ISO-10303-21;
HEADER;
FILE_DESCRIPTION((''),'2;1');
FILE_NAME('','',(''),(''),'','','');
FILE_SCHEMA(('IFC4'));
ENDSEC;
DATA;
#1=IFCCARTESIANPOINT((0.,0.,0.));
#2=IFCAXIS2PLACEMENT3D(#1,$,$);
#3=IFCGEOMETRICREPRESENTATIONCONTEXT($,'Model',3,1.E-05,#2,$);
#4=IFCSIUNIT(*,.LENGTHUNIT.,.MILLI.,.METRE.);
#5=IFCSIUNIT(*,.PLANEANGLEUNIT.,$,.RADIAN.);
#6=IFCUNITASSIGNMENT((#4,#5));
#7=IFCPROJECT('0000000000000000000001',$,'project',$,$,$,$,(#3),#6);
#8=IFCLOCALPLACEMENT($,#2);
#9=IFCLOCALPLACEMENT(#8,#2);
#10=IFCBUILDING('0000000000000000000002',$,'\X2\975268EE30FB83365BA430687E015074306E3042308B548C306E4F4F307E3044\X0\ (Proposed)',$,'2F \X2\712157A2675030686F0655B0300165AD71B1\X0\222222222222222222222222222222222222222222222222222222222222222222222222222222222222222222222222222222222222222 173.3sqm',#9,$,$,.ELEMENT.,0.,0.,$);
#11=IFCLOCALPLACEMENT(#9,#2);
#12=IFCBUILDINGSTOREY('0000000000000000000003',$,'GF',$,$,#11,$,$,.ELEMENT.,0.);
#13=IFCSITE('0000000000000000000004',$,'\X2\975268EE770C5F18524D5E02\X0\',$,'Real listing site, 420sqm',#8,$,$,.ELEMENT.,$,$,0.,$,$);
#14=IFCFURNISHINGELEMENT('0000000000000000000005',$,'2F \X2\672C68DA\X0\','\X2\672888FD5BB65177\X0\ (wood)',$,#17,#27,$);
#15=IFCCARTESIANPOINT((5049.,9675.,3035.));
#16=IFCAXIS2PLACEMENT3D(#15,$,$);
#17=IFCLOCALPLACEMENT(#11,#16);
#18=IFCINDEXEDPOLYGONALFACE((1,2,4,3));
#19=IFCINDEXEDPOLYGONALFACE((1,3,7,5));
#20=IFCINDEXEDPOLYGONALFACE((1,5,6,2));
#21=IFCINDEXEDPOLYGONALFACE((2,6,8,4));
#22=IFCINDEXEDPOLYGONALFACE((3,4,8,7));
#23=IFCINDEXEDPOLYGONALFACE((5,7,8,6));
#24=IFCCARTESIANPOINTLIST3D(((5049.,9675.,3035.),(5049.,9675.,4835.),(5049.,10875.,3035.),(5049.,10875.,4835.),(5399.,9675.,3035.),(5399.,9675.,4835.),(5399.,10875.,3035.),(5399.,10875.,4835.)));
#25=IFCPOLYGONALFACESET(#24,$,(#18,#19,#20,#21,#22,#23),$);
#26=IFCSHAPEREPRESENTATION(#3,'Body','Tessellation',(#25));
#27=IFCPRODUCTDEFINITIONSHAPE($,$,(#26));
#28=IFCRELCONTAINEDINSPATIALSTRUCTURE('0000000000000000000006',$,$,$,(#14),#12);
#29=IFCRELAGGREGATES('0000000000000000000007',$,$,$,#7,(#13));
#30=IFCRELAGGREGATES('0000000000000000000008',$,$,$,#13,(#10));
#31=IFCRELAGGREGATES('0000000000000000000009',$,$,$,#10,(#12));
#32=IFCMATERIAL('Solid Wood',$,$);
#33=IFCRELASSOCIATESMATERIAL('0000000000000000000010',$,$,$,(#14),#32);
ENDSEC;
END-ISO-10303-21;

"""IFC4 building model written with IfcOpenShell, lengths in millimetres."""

from ifc_helpers import new_model, si_unit, frame, frame_2d, origin, place, context, project, spatial, rectangle, extrude, material, element, save


model = new_model("IFC4")

# Units and contexts
model_context = context("Model", 3, precision=1e-05, world=origin())
ifc_project = project(units=[si_unit("LENGTHUNIT", "METRE", prefix="MILLI"), si_unit("PLANEANGLEUNIT", "RADIAN")], contexts=[model_context])

# Site, building, storey
site_placement = place(None, origin())
site = spatial("IfcSite", under=ifc_project, at=site_placement, Name="青森県弘前市", ObjectType="Real listing site, 420sqm", CompositionType="ELEMENT", RefElevation=0.0)
building_placement = place(site_placement, origin())
building = spatial("IfcBuilding", under=site, at=building_placement, Name="青森・茶室と縁側のある和の住まい (Proposed)", ObjectType="2F 無垢材と漆喰、断熱222222222222222222222222222222222222222222222222222222222222222222222222222222222222222222222222222222222222222 173.3sqm", CompositionType="ELEMENT", ElevationOfRefHeight=0.0, ElevationOfTerrain=0.0)
storey_placement = place(building_placement, origin())
storey = spatial("IfcBuildingStorey", under=building, at=storey_placement, Name="GF", CompositionType="ELEMENT", Elevation=0.0)

# Shared definitions
ifc_material_1 = material(Name="Solid Wood")

# Furnishing element
furnishing_1_placement = place(storey_placement, frame((5049.0, 9675.0, 3035.0)))
element("IfcFurnishingElement", 1, at=furnishing_1_placement, inside=storey, material=ifc_material_1, Name="2F 本棚", Description="木製家具 (wood)", context=model_context, shape_type="SweptSolid", body=[
    extrude(rectangle(XDim=350.0, YDim=1200.0, at=frame_2d((175.0, 600.0))), frame((5049.0, 9675.0, 3035.0)), (0.0, 0.0, 1.0), 1800.0),
])

save(model, "model.ifc")
